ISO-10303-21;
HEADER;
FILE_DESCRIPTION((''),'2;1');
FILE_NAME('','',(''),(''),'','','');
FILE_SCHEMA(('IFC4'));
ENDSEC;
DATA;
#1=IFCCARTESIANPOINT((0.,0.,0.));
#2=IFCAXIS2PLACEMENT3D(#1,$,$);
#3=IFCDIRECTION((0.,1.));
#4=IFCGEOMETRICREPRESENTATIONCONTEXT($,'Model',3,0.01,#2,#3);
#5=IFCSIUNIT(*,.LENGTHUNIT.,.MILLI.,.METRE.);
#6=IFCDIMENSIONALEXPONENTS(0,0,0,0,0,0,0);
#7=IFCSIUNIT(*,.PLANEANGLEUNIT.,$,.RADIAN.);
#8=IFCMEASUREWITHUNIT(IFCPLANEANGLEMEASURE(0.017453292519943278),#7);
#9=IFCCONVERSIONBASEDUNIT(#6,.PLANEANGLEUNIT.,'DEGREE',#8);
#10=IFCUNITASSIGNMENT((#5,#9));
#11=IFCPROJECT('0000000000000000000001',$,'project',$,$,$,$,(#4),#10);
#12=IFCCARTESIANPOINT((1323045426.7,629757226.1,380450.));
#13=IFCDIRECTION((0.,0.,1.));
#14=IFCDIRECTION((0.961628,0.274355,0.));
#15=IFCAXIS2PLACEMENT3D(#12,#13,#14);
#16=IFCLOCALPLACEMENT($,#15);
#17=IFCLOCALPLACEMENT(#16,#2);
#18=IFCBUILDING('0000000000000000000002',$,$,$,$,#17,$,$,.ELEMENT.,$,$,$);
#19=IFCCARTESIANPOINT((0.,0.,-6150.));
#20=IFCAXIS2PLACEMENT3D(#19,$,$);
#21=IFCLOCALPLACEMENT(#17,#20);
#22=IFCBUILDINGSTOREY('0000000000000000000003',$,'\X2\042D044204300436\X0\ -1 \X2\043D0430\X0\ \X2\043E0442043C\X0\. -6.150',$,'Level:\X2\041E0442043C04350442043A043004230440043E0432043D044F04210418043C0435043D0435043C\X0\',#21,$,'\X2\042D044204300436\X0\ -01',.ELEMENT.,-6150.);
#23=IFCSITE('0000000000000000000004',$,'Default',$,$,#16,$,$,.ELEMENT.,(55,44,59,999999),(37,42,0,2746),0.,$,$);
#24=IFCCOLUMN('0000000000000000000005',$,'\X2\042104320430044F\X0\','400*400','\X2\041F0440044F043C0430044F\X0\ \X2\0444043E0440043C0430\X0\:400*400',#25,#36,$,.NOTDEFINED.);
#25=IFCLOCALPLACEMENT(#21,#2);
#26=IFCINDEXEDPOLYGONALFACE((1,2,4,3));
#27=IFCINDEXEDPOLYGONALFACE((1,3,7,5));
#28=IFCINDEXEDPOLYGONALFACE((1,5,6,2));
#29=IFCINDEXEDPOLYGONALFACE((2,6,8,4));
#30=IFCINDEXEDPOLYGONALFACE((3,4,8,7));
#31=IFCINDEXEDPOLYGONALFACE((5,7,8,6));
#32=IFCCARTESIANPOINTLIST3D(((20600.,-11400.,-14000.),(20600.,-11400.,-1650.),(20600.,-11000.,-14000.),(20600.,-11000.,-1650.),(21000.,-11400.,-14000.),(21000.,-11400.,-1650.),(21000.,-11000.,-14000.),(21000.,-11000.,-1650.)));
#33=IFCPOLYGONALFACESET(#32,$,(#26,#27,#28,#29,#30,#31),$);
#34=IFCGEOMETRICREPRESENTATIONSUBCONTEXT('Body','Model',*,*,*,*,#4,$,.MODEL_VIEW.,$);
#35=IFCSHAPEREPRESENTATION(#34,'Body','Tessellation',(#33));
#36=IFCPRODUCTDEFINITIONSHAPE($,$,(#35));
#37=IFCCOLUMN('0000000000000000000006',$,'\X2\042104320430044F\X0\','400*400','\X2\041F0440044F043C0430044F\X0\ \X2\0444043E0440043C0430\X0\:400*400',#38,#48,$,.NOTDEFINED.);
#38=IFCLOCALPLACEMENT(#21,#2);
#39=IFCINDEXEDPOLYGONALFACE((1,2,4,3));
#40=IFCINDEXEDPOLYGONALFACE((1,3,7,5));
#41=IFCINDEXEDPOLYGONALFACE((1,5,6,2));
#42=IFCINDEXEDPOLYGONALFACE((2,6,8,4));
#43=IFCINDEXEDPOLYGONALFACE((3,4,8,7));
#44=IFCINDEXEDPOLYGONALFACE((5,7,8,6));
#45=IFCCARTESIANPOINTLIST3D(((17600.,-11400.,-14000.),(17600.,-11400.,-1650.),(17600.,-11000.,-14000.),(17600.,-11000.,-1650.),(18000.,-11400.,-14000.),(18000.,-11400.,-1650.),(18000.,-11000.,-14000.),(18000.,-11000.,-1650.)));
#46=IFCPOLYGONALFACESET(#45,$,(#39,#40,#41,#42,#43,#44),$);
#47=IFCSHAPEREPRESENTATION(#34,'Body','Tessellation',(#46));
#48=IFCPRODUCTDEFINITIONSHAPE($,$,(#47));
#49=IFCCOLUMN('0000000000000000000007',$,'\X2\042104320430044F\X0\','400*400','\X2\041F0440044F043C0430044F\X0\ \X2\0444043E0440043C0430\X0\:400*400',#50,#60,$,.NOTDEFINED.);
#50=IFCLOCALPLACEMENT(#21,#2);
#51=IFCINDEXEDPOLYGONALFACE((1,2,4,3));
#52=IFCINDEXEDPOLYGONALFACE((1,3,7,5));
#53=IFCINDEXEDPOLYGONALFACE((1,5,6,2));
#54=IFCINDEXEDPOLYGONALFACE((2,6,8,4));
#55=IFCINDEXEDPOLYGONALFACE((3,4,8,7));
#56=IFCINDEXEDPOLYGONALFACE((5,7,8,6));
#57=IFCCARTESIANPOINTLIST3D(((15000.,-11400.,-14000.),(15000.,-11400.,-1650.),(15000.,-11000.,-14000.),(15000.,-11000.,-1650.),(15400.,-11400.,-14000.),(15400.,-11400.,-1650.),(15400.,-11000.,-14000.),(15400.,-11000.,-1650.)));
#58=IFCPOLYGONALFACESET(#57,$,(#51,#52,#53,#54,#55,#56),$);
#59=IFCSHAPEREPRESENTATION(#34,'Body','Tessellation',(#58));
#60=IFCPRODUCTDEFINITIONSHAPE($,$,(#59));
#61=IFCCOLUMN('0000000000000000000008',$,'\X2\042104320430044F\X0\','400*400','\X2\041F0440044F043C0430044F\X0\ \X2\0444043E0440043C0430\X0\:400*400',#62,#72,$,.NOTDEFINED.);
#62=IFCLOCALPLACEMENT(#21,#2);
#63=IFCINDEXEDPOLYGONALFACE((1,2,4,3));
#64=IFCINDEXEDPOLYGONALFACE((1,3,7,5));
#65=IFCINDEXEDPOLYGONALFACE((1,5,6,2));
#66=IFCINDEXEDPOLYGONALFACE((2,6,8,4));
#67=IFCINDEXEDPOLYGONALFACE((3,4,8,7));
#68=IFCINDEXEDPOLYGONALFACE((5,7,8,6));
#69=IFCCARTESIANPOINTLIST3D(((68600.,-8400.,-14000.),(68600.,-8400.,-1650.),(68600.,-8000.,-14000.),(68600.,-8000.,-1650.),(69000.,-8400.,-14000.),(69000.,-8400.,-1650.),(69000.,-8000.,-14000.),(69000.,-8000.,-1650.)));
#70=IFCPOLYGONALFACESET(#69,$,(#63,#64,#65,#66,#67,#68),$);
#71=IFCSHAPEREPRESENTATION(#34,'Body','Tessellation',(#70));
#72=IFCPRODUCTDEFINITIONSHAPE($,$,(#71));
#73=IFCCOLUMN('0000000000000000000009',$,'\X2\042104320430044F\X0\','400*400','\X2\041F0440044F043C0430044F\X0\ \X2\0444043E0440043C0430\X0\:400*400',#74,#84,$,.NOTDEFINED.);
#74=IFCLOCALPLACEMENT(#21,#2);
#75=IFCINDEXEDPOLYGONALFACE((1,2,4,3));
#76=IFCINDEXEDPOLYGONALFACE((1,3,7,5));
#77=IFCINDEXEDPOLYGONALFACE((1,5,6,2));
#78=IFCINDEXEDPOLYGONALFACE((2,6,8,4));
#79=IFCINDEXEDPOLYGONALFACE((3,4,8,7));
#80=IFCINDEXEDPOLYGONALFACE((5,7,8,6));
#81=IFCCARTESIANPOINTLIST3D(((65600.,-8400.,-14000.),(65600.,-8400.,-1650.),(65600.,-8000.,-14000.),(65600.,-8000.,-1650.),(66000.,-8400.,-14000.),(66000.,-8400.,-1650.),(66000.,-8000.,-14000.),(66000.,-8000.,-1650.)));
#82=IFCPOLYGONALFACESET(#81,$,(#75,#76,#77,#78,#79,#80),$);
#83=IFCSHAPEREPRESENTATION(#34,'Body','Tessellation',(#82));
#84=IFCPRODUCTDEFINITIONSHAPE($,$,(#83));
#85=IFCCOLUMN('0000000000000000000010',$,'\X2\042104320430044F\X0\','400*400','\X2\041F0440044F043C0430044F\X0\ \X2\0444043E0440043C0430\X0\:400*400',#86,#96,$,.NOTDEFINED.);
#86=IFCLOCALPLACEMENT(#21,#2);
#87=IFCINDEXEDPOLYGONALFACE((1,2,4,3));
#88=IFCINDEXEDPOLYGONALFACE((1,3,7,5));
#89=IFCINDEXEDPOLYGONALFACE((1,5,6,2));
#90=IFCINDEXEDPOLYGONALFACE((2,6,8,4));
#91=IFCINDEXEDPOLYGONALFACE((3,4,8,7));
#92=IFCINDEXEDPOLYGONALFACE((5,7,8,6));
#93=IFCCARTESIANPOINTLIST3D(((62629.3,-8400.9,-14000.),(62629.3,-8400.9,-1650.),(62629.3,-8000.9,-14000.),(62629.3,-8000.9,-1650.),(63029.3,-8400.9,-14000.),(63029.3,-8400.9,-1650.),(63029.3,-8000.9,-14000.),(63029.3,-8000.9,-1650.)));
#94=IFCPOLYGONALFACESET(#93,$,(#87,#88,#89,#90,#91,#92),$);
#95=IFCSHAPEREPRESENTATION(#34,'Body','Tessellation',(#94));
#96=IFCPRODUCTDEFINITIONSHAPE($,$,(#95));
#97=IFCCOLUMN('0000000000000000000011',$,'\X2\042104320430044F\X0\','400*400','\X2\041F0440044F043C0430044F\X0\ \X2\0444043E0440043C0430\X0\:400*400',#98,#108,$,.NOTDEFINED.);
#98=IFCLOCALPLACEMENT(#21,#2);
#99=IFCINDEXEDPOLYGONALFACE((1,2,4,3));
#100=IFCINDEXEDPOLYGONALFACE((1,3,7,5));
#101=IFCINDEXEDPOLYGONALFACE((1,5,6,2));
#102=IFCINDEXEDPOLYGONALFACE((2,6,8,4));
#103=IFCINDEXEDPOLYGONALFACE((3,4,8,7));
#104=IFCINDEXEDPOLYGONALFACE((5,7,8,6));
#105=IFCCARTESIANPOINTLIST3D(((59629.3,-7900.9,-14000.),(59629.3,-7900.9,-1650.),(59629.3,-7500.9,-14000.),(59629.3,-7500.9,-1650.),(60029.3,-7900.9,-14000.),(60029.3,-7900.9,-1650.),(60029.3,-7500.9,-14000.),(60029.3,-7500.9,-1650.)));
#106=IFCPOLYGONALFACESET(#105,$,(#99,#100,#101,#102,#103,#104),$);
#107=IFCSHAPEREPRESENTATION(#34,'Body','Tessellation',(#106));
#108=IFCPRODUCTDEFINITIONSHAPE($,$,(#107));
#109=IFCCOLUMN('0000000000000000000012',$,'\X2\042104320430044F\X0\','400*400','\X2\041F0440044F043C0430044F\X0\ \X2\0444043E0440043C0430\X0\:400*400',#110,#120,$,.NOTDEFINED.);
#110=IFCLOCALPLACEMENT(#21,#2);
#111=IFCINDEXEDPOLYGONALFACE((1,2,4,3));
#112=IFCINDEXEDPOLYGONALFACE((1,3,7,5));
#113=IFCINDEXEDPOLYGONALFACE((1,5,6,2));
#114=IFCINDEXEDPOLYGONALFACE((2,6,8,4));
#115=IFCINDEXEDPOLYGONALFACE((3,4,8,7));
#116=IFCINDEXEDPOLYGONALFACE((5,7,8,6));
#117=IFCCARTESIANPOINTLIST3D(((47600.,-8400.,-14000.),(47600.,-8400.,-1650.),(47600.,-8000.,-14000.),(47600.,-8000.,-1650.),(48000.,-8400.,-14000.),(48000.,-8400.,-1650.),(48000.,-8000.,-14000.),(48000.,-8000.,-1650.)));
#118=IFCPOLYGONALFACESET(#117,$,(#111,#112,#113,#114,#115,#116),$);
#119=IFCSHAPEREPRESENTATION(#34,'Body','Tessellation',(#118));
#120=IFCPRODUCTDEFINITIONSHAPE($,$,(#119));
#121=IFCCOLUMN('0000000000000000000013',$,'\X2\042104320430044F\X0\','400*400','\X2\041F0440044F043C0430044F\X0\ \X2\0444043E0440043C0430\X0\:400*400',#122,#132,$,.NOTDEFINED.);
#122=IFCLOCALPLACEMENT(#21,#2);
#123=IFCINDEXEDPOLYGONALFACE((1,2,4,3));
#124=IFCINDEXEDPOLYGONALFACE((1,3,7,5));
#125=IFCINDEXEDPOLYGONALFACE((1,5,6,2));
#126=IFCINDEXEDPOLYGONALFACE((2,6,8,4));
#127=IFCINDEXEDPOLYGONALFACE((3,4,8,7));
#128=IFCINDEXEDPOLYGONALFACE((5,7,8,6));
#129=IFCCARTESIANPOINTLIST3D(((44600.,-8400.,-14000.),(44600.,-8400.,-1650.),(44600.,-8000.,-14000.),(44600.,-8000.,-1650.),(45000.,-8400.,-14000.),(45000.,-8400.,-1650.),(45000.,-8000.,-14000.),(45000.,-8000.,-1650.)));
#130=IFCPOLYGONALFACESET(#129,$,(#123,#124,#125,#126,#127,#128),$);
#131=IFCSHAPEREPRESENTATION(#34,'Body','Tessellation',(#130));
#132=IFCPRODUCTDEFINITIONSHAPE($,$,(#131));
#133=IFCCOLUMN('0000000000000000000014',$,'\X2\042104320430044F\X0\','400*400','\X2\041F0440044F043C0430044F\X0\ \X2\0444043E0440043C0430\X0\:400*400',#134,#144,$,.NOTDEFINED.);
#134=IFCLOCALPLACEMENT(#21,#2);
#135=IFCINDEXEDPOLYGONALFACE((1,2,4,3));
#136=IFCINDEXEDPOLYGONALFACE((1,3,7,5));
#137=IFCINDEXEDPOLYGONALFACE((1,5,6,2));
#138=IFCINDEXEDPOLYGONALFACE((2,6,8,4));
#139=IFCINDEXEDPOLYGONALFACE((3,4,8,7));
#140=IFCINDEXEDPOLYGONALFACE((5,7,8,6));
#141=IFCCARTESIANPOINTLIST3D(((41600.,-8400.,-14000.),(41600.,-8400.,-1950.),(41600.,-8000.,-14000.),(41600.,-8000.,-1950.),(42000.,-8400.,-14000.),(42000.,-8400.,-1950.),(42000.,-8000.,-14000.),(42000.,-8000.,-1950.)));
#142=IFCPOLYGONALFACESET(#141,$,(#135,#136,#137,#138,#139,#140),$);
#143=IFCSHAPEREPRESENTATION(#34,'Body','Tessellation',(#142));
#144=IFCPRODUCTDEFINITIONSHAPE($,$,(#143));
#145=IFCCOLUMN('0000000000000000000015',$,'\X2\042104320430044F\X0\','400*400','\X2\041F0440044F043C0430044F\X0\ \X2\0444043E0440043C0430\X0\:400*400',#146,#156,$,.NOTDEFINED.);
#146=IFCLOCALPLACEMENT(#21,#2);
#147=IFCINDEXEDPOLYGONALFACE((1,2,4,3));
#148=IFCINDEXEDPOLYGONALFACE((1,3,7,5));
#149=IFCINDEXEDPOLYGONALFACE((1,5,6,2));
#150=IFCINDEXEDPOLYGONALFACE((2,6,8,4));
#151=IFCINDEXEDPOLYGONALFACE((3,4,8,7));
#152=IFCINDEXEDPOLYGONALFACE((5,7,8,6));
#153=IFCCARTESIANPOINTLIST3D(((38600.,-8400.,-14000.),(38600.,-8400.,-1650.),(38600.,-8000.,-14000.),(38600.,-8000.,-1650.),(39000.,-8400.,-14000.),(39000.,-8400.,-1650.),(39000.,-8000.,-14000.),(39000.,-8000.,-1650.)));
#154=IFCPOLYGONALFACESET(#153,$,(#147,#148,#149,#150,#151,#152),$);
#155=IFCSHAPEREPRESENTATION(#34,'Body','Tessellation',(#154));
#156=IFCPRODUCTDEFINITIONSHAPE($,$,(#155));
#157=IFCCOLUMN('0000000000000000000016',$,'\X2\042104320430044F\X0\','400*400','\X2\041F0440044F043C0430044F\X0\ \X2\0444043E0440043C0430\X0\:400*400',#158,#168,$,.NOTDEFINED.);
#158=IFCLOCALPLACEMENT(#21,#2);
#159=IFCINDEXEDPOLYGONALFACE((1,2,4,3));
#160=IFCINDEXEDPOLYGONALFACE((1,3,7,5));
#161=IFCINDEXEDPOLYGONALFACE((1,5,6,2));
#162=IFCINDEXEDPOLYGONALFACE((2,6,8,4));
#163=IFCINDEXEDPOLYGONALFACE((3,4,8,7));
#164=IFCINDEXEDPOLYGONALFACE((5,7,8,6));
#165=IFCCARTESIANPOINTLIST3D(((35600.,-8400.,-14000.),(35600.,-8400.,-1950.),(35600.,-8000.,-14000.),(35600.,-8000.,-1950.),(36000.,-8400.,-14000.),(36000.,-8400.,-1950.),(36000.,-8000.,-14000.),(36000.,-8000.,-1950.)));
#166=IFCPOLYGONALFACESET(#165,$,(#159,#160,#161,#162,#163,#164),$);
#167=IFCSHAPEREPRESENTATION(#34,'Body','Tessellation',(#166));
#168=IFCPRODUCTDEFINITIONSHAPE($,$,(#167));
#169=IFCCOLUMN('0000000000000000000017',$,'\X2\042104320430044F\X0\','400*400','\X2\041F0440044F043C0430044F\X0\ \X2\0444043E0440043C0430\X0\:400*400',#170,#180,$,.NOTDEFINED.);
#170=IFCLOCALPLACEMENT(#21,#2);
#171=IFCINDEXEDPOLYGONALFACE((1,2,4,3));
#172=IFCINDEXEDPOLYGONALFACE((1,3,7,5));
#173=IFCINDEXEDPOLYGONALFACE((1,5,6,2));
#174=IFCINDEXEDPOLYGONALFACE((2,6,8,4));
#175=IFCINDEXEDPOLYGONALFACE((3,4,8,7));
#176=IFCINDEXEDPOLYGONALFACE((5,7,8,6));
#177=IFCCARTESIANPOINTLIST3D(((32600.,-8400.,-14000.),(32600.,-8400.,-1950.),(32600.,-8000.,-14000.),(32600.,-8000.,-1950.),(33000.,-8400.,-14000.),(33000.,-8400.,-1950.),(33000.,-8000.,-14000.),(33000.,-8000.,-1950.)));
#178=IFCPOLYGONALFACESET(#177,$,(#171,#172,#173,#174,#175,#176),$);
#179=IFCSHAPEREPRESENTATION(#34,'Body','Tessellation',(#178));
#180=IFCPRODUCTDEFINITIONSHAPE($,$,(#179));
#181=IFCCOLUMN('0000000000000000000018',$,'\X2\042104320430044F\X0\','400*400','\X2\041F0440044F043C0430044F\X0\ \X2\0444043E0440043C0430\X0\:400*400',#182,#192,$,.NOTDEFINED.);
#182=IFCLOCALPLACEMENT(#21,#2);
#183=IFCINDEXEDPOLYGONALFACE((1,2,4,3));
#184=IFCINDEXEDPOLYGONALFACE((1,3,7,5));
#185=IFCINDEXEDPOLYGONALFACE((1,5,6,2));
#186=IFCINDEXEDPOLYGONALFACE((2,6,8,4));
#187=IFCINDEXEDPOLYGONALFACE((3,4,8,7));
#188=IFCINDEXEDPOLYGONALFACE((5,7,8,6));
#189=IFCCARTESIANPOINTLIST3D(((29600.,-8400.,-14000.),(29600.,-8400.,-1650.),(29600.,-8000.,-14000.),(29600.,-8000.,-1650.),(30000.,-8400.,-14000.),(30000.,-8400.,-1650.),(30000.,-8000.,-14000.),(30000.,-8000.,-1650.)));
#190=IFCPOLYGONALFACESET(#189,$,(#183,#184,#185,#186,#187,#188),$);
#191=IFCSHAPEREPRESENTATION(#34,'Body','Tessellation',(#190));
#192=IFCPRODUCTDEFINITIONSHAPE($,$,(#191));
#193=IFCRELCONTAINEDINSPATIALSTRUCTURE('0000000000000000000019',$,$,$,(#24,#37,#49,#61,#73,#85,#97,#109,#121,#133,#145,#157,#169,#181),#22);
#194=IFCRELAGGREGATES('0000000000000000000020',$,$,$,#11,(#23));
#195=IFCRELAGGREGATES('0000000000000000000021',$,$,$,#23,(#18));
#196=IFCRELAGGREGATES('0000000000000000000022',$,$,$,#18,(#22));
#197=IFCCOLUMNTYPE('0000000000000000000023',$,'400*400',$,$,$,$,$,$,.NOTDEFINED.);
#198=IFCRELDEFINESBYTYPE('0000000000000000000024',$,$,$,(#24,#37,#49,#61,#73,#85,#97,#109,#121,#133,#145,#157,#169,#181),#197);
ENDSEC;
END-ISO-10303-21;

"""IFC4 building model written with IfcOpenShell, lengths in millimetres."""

from ifc_helpers import new_model, entity, si_unit, converted_unit, direction, frame, origin, place, context, subcontext, project, spatial, indexed_curve, outline, extrude, type_object, element, save


model = new_model("IFC4")

# Units and contexts
model_context = context("Model", 3, precision=0.01, world=origin(), true_north=direction((0.0, 1.0)))
body_context = subcontext(model_context, "Body", "Model", "MODEL_VIEW")
ifc_project = project(units=[si_unit("LENGTHUNIT", "METRE", prefix="MILLI"), converted_unit("PLANEANGLEUNIT", "DEGREE", entity("IfcPlaneAngleMeasure", 0.017453292519943278), si_unit("PLANEANGLEUNIT", "RADIAN"), dimensions=[0, 0, 0, 0, 0, 0, 0])], contexts=[model_context])

# Site, building, storey
site_placement = place(None, frame((1323045426.7, 629757226.1, 380450.0), z_axis=(0.0, 0.0, 1.0), x_axis=(0.961628, 0.274355, 0.0)))
site = spatial("IfcSite", under=ifc_project, at=site_placement, Name="Default", CompositionType="ELEMENT", RefLatitude=(55, 44, 59, 999999), RefLongitude=(37, 42, 0, 2746), RefElevation=0.0)
building_placement = place(site_placement, origin())
building = spatial("IfcBuilding", under=site, at=building_placement, CompositionType="ELEMENT")
storey_placement = place(building_placement, frame((0.0, 0.0, -6150.0)))
storey = spatial("IfcBuildingStorey", under=building, at=storey_placement, Name="Этаж -1 на отм. -6.150", ObjectType="Level:ОтметкаУровняСИменем", LongName="Этаж -01", CompositionType="ELEMENT", Elevation=-6150.0)

# Columns
column_type = type_object("IfcColumnType", Name="400*400", PredefinedType="NOTDEFINED")
column_1_placement = place(storey_placement, origin())
element("IfcColumn", 1, at=column_1_placement, inside=storey, type_object=column_type, Name="Свая", Description="400*400", ObjectType="Прямая форма:400*400", PredefinedType="NOTDEFINED", context=body_context, shape_type="SweptSolid", body=[
    extrude(outline(indexed_curve([(-200.0, -200.0), (200.0, -200.0), (200.0, 200.0), (-200.0, 200.0), (-200.0, -200.0)], self_intersect=False)), frame((20800.0, -11200.0, -14000.0), z_axis=(0.0, 0.0, 1.0), x_axis=(0.0, 1.0, 0.0)), (0.0, 0.0, 1.0), 12350.0),
])
column_2_placement = place(storey_placement, origin())
element("IfcColumn", 2, at=column_2_placement, inside=storey, type_object=column_type, Name="Свая", Description="400*400", ObjectType="Прямая форма:400*400", PredefinedType="NOTDEFINED", context=body_context, shape_type="SweptSolid", body=[
    extrude(outline(indexed_curve([(-200.0, -200.0), (200.0, -200.0), (200.0, 200.0), (-200.0, 200.0), (-200.0, -200.0)], self_intersect=False)), frame((17800.0, -11200.0, -14000.0), z_axis=(0.0, 0.0, 1.0), x_axis=(0.0, 1.0, 0.0)), (0.0, 0.0, 1.0), 12350.0),
])
column_3_placement = place(storey_placement, origin())
element("IfcColumn", 3, at=column_3_placement, inside=storey, type_object=column_type, Name="Свая", Description="400*400", ObjectType="Прямая форма:400*400", PredefinedType="NOTDEFINED", context=body_context, shape_type="SweptSolid", body=[
    extrude(outline(indexed_curve([(-200.0, -200.0), (200.0, -200.0), (200.0, 200.0), (-200.0, 200.0), (-200.0, -200.0)], self_intersect=False)), frame((15200.0, -11200.0, -14000.0), z_axis=(0.0, 0.0, 1.0), x_axis=(0.0, 1.0, 0.0)), (0.0, 0.0, 1.0), 12350.0),
])
column_4_placement = place(storey_placement, origin())
element("IfcColumn", 4, at=column_4_placement, inside=storey, type_object=column_type, Name="Свая", Description="400*400", ObjectType="Прямая форма:400*400", PredefinedType="NOTDEFINED", context=body_context, shape_type="SweptSolid", body=[
    extrude(outline(indexed_curve([(-200.0, -200.0), (200.0, -200.0), (200.0, 200.0), (-200.0, 200.0), (-200.0, -200.0)], self_intersect=False)), frame((68800.0, -8200.0, -14000.0), z_axis=(0.0, 0.0, 1.0), x_axis=(0.0, 1.0, 0.0)), (0.0, 0.0, 1.0), 12350.0),
])
column_5_placement = place(storey_placement, origin())
element("IfcColumn", 5, at=column_5_placement, inside=storey, type_object=column_type, Name="Свая", Description="400*400", ObjectType="Прямая форма:400*400", PredefinedType="NOTDEFINED", context=body_context, shape_type="SweptSolid", body=[
    extrude(outline(indexed_curve([(-200.0, -200.0), (200.0, -200.0), (200.0, 200.0), (-200.0, 200.0), (-200.0, -200.0)], self_intersect=False)), frame((65800.0, -8200.0, -14000.0), z_axis=(0.0, 0.0, 1.0), x_axis=(0.0, 1.0, 0.0)), (0.0, 0.0, 1.0), 12350.0),
])
column_6_placement = place(storey_placement, origin())
element("IfcColumn", 6, at=column_6_placement, inside=storey, type_object=column_type, Name="Свая", Description="400*400", ObjectType="Прямая форма:400*400", PredefinedType="NOTDEFINED", context=body_context, shape_type="SweptSolid", body=[
    extrude(outline(indexed_curve([(-200.0, -200.0), (200.0, -200.0), (200.0, 200.0), (-200.0, 200.0), (-200.0, -200.0)], self_intersect=False)), frame((62829.3, -8200.9, -14000.0), z_axis=(0.0, 0.0, 1.0), x_axis=(0.0, 1.0, 0.0)), (0.0, 0.0, 1.0), 12350.0),
])
column_7_placement = place(storey_placement, origin())
element("IfcColumn", 7, at=column_7_placement, inside=storey, type_object=column_type, Name="Свая", Description="400*400", ObjectType="Прямая форма:400*400", PredefinedType="NOTDEFINED", context=body_context, shape_type="SweptSolid", body=[
    extrude(outline(indexed_curve([(-200.0, -200.0), (200.0, -200.0), (200.0, 200.0), (-200.0, 200.0), (-200.0, -200.0)], self_intersect=False)), frame((59829.3, -7700.9, -14000.0), z_axis=(0.0, 0.0, 1.0), x_axis=(0.0, 1.0, 0.0)), (0.0, 0.0, 1.0), 12350.0),
])
column_8_placement = place(storey_placement, origin())
element("IfcColumn", 8, at=column_8_placement, inside=storey, type_object=column_type, Name="Свая", Description="400*400", ObjectType="Прямая форма:400*400", PredefinedType="NOTDEFINED", context=body_context, shape_type="SweptSolid", body=[
    extrude(outline(indexed_curve([(-200.0, -200.0), (200.0, -200.0), (200.0, 200.0), (-200.0, 200.0), (-200.0, -200.0)], self_intersect=False)), frame((47800.0, -8200.0, -14000.0), z_axis=(0.0, 0.0, 1.0), x_axis=(0.0, 1.0, 0.0)), (0.0, 0.0, 1.0), 12350.0),
])
column_9_placement = place(storey_placement, origin())
element("IfcColumn", 9, at=column_9_placement, inside=storey, type_object=column_type, Name="Свая", Description="400*400", ObjectType="Прямая форма:400*400", PredefinedType="NOTDEFINED", context=body_context, shape_type="SweptSolid", body=[
    extrude(outline(indexed_curve([(-200.0, -200.0), (200.0, -200.0), (200.0, 200.0), (-200.0, 200.0), (-200.0, -200.0)], self_intersect=False)), frame((44800.0, -8200.0, -14000.0), z_axis=(0.0, 0.0, 1.0), x_axis=(0.0, 1.0, 0.0)), (0.0, 0.0, 1.0), 12350.0),
])
column_10_placement = place(storey_placement, origin())
element("IfcColumn", 10, at=column_10_placement, inside=storey, type_object=column_type, Name="Свая", Description="400*400", ObjectType="Прямая форма:400*400", PredefinedType="NOTDEFINED", context=body_context, shape_type="SweptSolid", body=[
    extrude(outline(indexed_curve([(-200.0, -200.0), (200.0, -200.0), (200.0, 200.0), (-200.0, 200.0), (-200.0, -200.0)], self_intersect=False)), frame((41800.0, -8200.0, -14000.0), z_axis=(0.0, 0.0, 1.0), x_axis=(0.0, 1.0, 0.0)), (0.0, 0.0, 1.0), 12050.0),
])
column_11_placement = place(storey_placement, origin())
element("IfcColumn", 11, at=column_11_placement, inside=storey, type_object=column_type, Name="Свая", Description="400*400", ObjectType="Прямая форма:400*400", PredefinedType="NOTDEFINED", context=body_context, shape_type="SweptSolid", body=[
    extrude(outline(indexed_curve([(-200.0, -200.0), (200.0, -200.0), (200.0, 200.0), (-200.0, 200.0), (-200.0, -200.0)], self_intersect=False)), frame((38800.0, -8200.0, -14000.0), z_axis=(0.0, 0.0, 1.0), x_axis=(0.0, 1.0, 0.0)), (0.0, 0.0, 1.0), 12350.0),
])
column_12_placement = place(storey_placement, origin())
element("IfcColumn", 12, at=column_12_placement, inside=storey, type_object=column_type, Name="Свая", Description="400*400", ObjectType="Прямая форма:400*400", PredefinedType="NOTDEFINED", context=body_context, shape_type="SweptSolid", body=[
    extrude(outline(indexed_curve([(-200.0, -200.0), (200.0, -200.0), (200.0, 200.0), (-200.0, 200.0), (-200.0, -200.0)], self_intersect=False)), frame((35800.0, -8200.0, -14000.0), z_axis=(0.0, 0.0, 1.0), x_axis=(0.0, 1.0, 0.0)), (0.0, 0.0, 1.0), 12050.0),
])
column_13_placement = place(storey_placement, origin())
element("IfcColumn", 13, at=column_13_placement, inside=storey, type_object=column_type, Name="Свая", Description="400*400", ObjectType="Прямая форма:400*400", PredefinedType="NOTDEFINED", context=body_context, shape_type="SweptSolid", body=[
    extrude(outline(indexed_curve([(-200.0, -200.0), (200.0, -200.0), (200.0, 200.0), (-200.0, 200.0), (-200.0, -200.0)], self_intersect=False)), frame((32800.0, -8200.0, -14000.0), z_axis=(0.0, 0.0, 1.0), x_axis=(0.0, 1.0, 0.0)), (0.0, 0.0, 1.0), 12050.0),
])
column_14_placement = place(storey_placement, origin())
element("IfcColumn", 14, at=column_14_placement, inside=storey, type_object=column_type, Name="Свая", Description="400*400", ObjectType="Прямая форма:400*400", PredefinedType="NOTDEFINED", context=body_context, shape_type="SweptSolid", body=[
    extrude(outline(indexed_curve([(-200.0, -200.0), (200.0, -200.0), (200.0, 200.0), (-200.0, 200.0), (-200.0, -200.0)], self_intersect=False)), frame((29800.0, -8200.0, -14000.0), z_axis=(0.0, 0.0, 1.0), x_axis=(0.0, 1.0, 0.0)), (0.0, 0.0, 1.0), 12350.0),
])

save(model, "model.ifc")
